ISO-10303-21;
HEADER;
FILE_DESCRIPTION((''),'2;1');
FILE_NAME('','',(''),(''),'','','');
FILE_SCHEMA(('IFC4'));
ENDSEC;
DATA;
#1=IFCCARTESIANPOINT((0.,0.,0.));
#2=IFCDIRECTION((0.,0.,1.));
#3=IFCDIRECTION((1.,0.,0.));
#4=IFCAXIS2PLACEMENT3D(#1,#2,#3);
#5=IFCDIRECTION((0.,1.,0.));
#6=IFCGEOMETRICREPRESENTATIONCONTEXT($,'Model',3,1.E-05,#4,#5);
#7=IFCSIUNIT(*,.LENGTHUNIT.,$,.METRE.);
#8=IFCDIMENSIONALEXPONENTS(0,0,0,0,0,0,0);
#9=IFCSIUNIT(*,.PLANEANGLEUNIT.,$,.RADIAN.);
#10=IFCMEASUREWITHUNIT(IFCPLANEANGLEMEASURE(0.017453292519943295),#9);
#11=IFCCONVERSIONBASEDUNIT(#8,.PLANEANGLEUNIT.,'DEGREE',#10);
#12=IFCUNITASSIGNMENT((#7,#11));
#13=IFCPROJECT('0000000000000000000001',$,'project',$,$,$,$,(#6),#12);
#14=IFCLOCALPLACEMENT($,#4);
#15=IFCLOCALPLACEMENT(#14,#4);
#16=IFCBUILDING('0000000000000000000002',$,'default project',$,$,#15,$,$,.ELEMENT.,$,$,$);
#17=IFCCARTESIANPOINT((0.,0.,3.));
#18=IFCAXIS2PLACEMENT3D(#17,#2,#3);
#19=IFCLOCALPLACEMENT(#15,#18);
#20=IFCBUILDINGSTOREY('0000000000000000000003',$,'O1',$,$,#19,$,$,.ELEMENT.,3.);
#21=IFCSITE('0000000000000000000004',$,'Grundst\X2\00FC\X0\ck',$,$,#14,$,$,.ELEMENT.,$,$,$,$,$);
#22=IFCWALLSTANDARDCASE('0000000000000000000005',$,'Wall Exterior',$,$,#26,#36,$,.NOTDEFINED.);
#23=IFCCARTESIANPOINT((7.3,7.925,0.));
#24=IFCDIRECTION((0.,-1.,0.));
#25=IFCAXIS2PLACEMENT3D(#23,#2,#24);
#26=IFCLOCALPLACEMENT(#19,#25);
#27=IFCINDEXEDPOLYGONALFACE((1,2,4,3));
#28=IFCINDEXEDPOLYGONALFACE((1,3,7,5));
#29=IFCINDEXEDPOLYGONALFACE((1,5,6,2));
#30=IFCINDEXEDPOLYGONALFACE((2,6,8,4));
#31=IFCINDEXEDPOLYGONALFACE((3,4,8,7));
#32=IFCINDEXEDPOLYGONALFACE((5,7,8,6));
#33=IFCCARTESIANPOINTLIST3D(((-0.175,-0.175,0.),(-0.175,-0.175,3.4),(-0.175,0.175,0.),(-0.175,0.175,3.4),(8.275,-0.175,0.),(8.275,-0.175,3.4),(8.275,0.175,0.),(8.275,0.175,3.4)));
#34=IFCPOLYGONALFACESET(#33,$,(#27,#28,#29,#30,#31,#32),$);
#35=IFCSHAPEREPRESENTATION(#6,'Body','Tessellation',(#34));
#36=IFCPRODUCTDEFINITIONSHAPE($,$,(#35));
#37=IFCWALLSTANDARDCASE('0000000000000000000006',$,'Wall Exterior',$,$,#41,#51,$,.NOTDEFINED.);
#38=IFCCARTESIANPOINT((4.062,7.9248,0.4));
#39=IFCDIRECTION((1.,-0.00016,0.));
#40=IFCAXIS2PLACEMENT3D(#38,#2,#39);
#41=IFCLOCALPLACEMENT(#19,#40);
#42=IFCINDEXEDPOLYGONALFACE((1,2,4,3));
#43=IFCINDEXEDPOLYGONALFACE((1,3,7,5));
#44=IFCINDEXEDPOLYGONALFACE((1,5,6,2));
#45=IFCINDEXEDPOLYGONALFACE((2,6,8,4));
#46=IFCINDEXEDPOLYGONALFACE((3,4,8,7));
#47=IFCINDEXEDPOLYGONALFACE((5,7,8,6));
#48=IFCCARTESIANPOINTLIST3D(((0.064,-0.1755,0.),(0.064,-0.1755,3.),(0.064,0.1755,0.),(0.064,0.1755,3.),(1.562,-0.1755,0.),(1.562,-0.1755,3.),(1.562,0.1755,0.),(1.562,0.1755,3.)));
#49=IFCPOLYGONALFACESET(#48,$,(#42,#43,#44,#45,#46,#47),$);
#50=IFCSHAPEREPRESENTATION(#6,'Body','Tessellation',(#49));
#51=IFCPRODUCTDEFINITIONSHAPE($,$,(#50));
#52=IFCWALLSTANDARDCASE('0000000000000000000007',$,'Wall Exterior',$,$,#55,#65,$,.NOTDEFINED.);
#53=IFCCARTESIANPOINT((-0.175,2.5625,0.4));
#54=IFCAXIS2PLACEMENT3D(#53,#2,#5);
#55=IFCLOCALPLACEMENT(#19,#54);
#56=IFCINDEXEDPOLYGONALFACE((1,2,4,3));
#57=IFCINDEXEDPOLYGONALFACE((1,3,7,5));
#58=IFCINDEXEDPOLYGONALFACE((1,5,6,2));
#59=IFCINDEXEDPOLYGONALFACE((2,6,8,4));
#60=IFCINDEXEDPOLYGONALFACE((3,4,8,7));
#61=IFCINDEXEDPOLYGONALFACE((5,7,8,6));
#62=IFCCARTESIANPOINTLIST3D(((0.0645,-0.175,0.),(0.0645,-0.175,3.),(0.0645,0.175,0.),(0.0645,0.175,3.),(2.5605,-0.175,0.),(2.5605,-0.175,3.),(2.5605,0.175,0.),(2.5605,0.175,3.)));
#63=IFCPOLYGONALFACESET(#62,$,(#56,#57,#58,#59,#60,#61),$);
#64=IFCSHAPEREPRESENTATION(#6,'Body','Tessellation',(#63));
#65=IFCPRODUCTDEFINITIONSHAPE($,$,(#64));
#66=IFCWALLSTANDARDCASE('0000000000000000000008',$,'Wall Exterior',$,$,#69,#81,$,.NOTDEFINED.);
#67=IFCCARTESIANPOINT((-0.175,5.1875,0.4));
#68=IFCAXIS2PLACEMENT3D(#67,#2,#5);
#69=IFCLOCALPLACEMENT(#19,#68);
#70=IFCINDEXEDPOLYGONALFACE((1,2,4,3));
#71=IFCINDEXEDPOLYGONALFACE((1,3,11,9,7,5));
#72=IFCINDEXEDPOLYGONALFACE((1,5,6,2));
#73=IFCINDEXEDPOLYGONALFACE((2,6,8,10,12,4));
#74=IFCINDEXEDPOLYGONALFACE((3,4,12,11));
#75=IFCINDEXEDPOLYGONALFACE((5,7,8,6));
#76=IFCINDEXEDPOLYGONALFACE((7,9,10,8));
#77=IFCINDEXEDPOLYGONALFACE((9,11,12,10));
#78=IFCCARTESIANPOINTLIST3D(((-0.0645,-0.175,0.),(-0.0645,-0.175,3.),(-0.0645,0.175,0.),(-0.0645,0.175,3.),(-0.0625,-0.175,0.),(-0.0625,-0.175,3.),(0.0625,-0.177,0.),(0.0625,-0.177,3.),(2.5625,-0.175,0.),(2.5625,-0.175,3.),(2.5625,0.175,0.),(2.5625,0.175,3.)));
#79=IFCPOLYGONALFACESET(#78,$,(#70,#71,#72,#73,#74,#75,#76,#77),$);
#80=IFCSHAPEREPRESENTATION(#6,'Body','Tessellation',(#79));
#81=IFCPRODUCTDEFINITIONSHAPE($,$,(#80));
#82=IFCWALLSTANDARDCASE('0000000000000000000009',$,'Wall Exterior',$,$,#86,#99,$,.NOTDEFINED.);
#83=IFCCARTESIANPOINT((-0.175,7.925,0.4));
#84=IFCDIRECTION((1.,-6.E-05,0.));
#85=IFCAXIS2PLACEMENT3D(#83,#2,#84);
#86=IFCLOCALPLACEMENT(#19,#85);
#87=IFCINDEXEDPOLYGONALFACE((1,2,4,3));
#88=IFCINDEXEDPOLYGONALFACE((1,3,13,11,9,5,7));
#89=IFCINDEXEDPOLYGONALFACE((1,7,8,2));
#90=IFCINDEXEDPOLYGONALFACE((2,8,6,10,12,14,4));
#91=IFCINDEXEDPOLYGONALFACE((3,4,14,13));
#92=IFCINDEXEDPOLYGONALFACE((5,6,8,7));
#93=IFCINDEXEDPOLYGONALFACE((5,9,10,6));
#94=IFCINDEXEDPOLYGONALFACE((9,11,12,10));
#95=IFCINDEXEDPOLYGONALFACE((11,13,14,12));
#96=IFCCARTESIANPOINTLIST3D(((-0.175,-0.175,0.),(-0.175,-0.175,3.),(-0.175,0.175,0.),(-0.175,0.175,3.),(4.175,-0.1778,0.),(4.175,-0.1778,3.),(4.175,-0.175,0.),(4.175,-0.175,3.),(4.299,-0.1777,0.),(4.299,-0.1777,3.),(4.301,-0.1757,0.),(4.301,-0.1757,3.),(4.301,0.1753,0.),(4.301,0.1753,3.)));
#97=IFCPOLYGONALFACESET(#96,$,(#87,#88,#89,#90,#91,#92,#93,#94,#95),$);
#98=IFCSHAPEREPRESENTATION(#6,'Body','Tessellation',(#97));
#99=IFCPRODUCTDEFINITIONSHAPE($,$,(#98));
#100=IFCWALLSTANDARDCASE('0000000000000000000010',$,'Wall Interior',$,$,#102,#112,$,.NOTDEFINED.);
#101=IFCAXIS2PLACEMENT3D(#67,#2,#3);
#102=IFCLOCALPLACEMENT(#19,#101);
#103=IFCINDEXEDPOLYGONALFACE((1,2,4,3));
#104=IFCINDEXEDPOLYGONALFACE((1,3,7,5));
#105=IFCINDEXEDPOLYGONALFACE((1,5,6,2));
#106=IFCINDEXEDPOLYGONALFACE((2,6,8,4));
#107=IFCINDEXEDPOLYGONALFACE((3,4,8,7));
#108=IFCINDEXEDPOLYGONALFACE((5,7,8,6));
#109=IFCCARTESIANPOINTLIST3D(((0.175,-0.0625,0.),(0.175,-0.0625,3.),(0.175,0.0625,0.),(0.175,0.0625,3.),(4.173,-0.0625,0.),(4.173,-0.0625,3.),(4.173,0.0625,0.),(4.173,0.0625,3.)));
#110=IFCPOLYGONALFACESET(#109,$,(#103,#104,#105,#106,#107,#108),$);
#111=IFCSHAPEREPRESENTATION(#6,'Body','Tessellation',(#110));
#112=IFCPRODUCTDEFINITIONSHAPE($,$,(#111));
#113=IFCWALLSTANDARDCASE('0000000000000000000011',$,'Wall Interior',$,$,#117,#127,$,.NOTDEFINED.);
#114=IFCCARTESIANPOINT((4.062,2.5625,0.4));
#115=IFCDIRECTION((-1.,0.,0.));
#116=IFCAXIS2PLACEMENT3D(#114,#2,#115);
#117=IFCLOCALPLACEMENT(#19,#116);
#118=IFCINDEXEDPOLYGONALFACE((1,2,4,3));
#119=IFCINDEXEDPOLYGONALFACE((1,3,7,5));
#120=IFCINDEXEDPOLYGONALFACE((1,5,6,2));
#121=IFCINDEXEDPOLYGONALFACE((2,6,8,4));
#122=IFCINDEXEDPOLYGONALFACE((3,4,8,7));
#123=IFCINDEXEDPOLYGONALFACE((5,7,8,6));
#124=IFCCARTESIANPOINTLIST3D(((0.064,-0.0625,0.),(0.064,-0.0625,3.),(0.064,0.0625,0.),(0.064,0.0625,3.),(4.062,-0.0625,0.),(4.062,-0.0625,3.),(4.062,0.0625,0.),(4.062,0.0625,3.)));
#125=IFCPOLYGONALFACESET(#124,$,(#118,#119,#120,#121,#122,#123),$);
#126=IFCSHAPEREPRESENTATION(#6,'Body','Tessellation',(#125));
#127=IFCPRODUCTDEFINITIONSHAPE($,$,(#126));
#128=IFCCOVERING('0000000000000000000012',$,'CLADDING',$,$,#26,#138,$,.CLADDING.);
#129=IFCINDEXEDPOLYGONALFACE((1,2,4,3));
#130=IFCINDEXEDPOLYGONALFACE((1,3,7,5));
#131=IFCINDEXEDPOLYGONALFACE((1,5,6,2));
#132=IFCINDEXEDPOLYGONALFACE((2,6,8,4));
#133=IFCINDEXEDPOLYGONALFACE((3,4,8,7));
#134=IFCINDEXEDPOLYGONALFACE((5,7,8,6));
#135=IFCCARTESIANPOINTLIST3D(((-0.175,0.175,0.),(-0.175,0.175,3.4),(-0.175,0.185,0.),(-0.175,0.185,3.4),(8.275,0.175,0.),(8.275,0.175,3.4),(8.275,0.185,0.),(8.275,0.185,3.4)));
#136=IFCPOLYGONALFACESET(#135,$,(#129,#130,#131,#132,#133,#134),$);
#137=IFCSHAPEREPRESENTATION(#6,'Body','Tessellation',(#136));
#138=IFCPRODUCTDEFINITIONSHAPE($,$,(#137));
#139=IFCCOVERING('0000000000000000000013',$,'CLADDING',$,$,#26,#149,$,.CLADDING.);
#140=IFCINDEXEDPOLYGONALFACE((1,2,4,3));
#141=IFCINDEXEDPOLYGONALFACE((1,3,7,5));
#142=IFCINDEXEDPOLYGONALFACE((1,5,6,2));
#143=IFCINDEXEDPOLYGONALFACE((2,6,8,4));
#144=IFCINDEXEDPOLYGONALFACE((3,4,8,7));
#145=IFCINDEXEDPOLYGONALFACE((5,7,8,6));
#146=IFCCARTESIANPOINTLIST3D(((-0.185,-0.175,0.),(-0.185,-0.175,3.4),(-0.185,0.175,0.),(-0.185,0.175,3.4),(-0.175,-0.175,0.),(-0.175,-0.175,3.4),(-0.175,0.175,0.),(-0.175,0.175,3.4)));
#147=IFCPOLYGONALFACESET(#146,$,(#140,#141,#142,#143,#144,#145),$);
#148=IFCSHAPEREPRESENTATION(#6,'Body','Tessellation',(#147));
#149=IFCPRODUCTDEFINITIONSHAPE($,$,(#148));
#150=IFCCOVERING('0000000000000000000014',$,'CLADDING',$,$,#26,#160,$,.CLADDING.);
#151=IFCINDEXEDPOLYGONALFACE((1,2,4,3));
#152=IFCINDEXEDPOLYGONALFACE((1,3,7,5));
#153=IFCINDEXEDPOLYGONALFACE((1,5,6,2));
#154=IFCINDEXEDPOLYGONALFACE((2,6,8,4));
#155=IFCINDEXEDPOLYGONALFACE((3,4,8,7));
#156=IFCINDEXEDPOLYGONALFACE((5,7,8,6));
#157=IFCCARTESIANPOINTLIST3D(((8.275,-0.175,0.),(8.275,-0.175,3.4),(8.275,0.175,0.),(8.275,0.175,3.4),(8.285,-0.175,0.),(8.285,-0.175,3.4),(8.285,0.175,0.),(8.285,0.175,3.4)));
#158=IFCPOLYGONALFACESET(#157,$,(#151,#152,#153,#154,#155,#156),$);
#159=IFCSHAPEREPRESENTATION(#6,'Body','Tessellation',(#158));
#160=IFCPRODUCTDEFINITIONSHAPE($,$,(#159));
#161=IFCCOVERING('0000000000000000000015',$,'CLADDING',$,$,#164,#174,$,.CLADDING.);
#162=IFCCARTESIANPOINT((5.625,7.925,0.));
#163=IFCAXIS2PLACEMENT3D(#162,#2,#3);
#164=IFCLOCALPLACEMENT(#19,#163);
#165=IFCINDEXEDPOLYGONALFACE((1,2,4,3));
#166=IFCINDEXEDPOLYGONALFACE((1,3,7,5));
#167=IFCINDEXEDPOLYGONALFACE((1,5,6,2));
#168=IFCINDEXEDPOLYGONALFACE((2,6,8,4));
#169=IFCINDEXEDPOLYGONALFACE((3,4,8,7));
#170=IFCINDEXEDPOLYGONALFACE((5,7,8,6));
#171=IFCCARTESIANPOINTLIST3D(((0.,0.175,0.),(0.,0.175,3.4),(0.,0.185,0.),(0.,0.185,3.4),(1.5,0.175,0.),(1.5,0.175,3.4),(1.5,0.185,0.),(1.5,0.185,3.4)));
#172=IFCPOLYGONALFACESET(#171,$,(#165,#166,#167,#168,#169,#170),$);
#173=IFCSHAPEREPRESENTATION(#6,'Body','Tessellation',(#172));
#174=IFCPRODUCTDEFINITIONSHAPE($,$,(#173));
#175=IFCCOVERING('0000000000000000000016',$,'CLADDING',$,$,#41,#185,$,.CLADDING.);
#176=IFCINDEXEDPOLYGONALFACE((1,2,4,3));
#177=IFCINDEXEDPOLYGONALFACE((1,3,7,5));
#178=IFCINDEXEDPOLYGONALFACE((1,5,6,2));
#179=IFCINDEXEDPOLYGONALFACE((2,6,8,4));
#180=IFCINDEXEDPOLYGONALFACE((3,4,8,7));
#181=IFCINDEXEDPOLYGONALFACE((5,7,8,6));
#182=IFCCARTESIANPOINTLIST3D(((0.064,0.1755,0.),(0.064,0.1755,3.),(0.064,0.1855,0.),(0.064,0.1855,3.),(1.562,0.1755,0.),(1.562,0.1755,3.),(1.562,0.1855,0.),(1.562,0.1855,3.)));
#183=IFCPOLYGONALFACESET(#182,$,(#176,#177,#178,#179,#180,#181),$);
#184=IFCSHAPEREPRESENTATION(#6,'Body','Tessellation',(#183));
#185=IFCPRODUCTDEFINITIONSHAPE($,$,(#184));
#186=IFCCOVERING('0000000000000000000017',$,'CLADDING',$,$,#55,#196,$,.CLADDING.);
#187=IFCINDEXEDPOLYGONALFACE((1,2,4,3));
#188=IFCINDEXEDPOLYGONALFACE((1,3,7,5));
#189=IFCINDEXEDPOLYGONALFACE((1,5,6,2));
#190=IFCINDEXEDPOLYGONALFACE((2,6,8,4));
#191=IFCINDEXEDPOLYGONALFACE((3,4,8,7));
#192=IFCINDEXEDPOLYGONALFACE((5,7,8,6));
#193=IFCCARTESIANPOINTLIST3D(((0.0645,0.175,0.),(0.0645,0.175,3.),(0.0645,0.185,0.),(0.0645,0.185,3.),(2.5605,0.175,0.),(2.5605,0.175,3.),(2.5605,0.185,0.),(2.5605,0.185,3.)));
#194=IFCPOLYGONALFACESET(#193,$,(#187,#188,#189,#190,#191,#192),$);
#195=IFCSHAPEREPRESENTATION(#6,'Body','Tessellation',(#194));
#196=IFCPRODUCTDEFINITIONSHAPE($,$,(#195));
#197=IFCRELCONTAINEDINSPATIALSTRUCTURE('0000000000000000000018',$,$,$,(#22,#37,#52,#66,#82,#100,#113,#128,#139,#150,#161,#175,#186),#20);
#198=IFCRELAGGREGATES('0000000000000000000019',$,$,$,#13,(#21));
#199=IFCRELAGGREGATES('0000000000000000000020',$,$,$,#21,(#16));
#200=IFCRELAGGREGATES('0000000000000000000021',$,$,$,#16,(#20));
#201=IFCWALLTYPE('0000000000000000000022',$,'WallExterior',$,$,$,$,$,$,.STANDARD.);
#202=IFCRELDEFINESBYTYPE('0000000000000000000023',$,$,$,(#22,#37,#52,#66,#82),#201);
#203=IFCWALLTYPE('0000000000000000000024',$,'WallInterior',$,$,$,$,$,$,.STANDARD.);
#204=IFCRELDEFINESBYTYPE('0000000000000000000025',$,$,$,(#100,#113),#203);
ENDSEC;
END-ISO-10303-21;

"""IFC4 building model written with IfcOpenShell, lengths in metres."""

from ifc_helpers import new_model, entity, si_unit, converted_unit, direction, frame, origin_with_axes, place, context, project, spatial, polyline, outline, extrude, type_object, element, save


model = new_model("IFC4")

# Units and contexts
model_context = context("Model", 3, precision=1e-05, world=origin_with_axes(), true_north=direction((0.0, 1.0, 0.0)))
ifc_project = project(units=[si_unit("LENGTHUNIT", "METRE"), converted_unit("PLANEANGLEUNIT", "DEGREE", entity("IfcPlaneAngleMeasure", 0.017453292519943295), si_unit("PLANEANGLEUNIT", "RADIAN"), dimensions=[0, 0, 0, 0, 0, 0, 0])], contexts=[model_context])

# Site, building, storey
site_placement = place(None, origin_with_axes())
site = spatial("IfcSite", under=ifc_project, at=site_placement, Name="Grundstück", CompositionType="ELEMENT")
building_placement = place(site_placement, origin_with_axes())
building = spatial("IfcBuilding", under=site, at=building_placement, Name="default project", CompositionType="ELEMENT")
placement_1 = place(building_placement, frame((0.0, 0.0, 3.0), z_axis=(0.0, 0.0, 1.0), x_axis=(1.0, 0.0, 0.0)))
storey = spatial("IfcBuildingStorey", under=building, at=placement_1, Name="O1", CompositionType="ELEMENT", Elevation=3.0)

# Walls
wall_type_1 = type_object("IfcWallType", Name="WallExterior", PredefinedType="STANDARD")
placement_2 = place(placement_1, frame((7.3, 7.925, 0.0), z_axis=(0.0, 0.0, 1.0), x_axis=(0.0, -1.0, 0.0)))
element("IfcWallStandardCase", 1, at=placement_2, inside=storey, type_object=wall_type_1, Name="Wall Exterior", PredefinedType="NOTDEFINED", context=model_context, shape_type="SweptSolid", body=[
    extrude(outline(polyline([(8.275, 0.175), (-0.175, 0.175), (-0.175, -0.175), (8.275, -0.175), (8.275, 0.175)])), origin_with_axes(), (0.0, 0.0, 1.0), 3.4),
])
placement_3 = place(placement_1, frame((5.625, 7.925, 0.0), z_axis=(0.0, 0.0, 1.0), x_axis=(1.0, 0.0, 0.0)))
placement_4 = place(placement_1, frame((4.062, 7.9248, 0.4), z_axis=(0.0, 0.0, 1.0), x_axis=(1.0, -0.00016, 0.0)))
element("IfcWallStandardCase", 2, at=placement_4, inside=storey, type_object=wall_type_1, Name="Wall Exterior", PredefinedType="NOTDEFINED", context=model_context, shape_type="SweptSolid", body=[
    extrude(outline(polyline([(1.562, 0.1755), (0.064, 0.1755), (0.064, -0.1755), (1.562, -0.1755), (1.562, 0.1755)])), origin_with_axes(), (0.0, 0.0, 1.0), 3.0),
])
placement_5 = place(placement_1, frame((-0.175, 2.5625, 0.4), z_axis=(0.0, 0.0, 1.0), x_axis=(0.0, 1.0, 0.0)))
element("IfcWallStandardCase", 3, at=placement_5, inside=storey, type_object=wall_type_1, Name="Wall Exterior", PredefinedType="NOTDEFINED", context=model_context, shape_type="SweptSolid", body=[
    extrude(outline(polyline([(0.0645, -0.175), (2.5605, -0.175), (2.5605, 0.175), (0.0645, 0.175), (0.0645, -0.175)])), origin_with_axes(), (0.0, 0.0, 1.0), 3.0),
])
placement_6 = place(placement_1, frame((-0.175, 5.1875, 0.4), z_axis=(0.0, 0.0, 1.0), x_axis=(0.0, 1.0, 0.0)))
element("IfcWallStandardCase", 4, at=placement_6, inside=storey, type_object=wall_type_1, Name="Wall Exterior", PredefinedType="NOTDEFINED", context=model_context, shape_type="SweptSolid", body=[
    extrude(outline(polyline([(-0.0625, -0.175), (0.0625, -0.177), (2.5625, -0.175), (2.5625, 0.175), (-0.0645, 0.175), (-0.0645, -0.175), (-0.0625, -0.175)])), origin_with_axes(), (0.0, 0.0, 1.0), 3.0),
])
placement_7 = place(placement_1, frame((-0.175, 7.925, 0.4), z_axis=(0.0, 0.0, 1.0), x_axis=(1.0, -0.00006, 0.0)))
element("IfcWallStandardCase", 5, at=placement_7, inside=storey, type_object=wall_type_1, Name="Wall Exterior", PredefinedType="NOTDEFINED", context=model_context, shape_type="SweptSolid", body=[
    extrude(outline(polyline([(-0.175, 0.175), (-0.175, -0.175), (4.175, -0.175), (4.175, -0.1778), (4.299, -0.1777), (4.301, -0.1757), (4.301, 0.1753), (-0.175, 0.175)])), origin_with_axes(), (0.0, 0.0, 1.0), 3.0),
])
wall_type_2 = type_object("IfcWallType", Name="WallInterior", PredefinedType="STANDARD")
wall_1_placement = place(placement_1, frame((-0.175, 5.1875, 0.4), z_axis=(0.0, 0.0, 1.0), x_axis=(1.0, 0.0, 0.0)))
element("IfcWallStandardCase", 6, at=wall_1_placement, inside=storey, type_object=wall_type_2, Name="Wall Interior", PredefinedType="NOTDEFINED", context=model_context, shape_type="SweptSolid", body=[
    extrude(outline(polyline([(4.173, 0.0625), (0.175, 0.0625), (0.175, -0.0625), (4.173, -0.0625), (4.173, 0.0625)])), origin_with_axes(), (0.0, 0.0, 1.0), 3.0),
])
wall_2_placement = place(placement_1, frame((4.062, 2.5625, 0.4), z_axis=(0.0, 0.0, 1.0), x_axis=(-1.0, 0.0, 0.0)))
element("IfcWallStandardCase", 7, at=wall_2_placement, inside=storey, type_object=wall_type_2, Name="Wall Interior", PredefinedType="NOTDEFINED", context=model_context, shape_type="SweptSolid", body=[
    extrude(outline(polyline([(0.064, -0.0625), (4.062, -0.0625), (4.062, 0.0625), (0.064, 0.0625), (0.064, -0.0625)])), origin_with_axes(), (0.0, 0.0, 1.0), 3.0),
])

# Coverings
element("IfcCovering", 8, at=placement_2, inside=storey, Name="CLADDING", PredefinedType="CLADDING", context=model_context, shape_type="SweptSolid", body=[
    extrude(outline(polyline([(8.275, 0.185), (-0.175, 0.185), (-0.175, 0.175), (8.275, 0.175), (8.275, 0.185)])), origin_with_axes(), (0.0, 0.0, 1.0), 3.4),
])
element("IfcCovering", 9, at=placement_2, inside=storey, Name="CLADDING", PredefinedType="CLADDING", context=model_context, shape_type="SweptSolid", body=[
    extrude(outline(polyline([(-0.185, 0.175), (-0.185, -0.175), (-0.175, -0.175), (-0.175, 0.175), (-0.185, 0.175)])), origin_with_axes(), (0.0, 0.0, 1.0), 3.4),
])
element("IfcCovering", 10, at=placement_2, inside=storey, Name="CLADDING", PredefinedType="CLADDING", context=model_context, shape_type="SweptSolid", body=[
    extrude(outline(polyline([(8.285, -0.175), (8.285, 0.175), (8.275, 0.175), (8.275, -0.175), (8.285, -0.175)])), origin_with_axes(), (0.0, 0.0, 1.0), 3.4),
])
element("IfcCovering", 11, at=placement_3, inside=storey, Name="CLADDING", PredefinedType="CLADDING", context=model_context, shape_type="SweptSolid", body=[
    extrude(outline(polyline([(1.5, 0.185), (0.0, 0.185), (0.0, 0.175), (1.5, 0.175), (1.5, 0.185)])), origin_with_axes(), (0.0, 0.0, 1.0), 3.4),
])
element("IfcCovering", 12, at=placement_4, inside=storey, Name="CLADDING", PredefinedType="CLADDING", context=model_context, shape_type="SweptSolid", body=[
    extrude(outline(polyline([(1.562, 0.1855), (0.064, 0.1855), (0.064, 0.1755), (1.562, 0.1755), (1.562, 0.1855)])), origin_with_axes(), (0.0, 0.0, 1.0), 3.0),
])
element("IfcCovering", 13, at=placement_5, inside=storey, Name="CLADDING", PredefinedType="CLADDING", context=model_context, shape_type="SweptSolid", body=[
    extrude(outline(polyline([(2.5605, 0.185), (0.0645, 0.185), (0.0645, 0.175), (2.5605, 0.175), (2.5605, 0.185)])), origin_with_axes(), (0.0, 0.0, 1.0), 3.0),
])

save(model, "model.ifc")
